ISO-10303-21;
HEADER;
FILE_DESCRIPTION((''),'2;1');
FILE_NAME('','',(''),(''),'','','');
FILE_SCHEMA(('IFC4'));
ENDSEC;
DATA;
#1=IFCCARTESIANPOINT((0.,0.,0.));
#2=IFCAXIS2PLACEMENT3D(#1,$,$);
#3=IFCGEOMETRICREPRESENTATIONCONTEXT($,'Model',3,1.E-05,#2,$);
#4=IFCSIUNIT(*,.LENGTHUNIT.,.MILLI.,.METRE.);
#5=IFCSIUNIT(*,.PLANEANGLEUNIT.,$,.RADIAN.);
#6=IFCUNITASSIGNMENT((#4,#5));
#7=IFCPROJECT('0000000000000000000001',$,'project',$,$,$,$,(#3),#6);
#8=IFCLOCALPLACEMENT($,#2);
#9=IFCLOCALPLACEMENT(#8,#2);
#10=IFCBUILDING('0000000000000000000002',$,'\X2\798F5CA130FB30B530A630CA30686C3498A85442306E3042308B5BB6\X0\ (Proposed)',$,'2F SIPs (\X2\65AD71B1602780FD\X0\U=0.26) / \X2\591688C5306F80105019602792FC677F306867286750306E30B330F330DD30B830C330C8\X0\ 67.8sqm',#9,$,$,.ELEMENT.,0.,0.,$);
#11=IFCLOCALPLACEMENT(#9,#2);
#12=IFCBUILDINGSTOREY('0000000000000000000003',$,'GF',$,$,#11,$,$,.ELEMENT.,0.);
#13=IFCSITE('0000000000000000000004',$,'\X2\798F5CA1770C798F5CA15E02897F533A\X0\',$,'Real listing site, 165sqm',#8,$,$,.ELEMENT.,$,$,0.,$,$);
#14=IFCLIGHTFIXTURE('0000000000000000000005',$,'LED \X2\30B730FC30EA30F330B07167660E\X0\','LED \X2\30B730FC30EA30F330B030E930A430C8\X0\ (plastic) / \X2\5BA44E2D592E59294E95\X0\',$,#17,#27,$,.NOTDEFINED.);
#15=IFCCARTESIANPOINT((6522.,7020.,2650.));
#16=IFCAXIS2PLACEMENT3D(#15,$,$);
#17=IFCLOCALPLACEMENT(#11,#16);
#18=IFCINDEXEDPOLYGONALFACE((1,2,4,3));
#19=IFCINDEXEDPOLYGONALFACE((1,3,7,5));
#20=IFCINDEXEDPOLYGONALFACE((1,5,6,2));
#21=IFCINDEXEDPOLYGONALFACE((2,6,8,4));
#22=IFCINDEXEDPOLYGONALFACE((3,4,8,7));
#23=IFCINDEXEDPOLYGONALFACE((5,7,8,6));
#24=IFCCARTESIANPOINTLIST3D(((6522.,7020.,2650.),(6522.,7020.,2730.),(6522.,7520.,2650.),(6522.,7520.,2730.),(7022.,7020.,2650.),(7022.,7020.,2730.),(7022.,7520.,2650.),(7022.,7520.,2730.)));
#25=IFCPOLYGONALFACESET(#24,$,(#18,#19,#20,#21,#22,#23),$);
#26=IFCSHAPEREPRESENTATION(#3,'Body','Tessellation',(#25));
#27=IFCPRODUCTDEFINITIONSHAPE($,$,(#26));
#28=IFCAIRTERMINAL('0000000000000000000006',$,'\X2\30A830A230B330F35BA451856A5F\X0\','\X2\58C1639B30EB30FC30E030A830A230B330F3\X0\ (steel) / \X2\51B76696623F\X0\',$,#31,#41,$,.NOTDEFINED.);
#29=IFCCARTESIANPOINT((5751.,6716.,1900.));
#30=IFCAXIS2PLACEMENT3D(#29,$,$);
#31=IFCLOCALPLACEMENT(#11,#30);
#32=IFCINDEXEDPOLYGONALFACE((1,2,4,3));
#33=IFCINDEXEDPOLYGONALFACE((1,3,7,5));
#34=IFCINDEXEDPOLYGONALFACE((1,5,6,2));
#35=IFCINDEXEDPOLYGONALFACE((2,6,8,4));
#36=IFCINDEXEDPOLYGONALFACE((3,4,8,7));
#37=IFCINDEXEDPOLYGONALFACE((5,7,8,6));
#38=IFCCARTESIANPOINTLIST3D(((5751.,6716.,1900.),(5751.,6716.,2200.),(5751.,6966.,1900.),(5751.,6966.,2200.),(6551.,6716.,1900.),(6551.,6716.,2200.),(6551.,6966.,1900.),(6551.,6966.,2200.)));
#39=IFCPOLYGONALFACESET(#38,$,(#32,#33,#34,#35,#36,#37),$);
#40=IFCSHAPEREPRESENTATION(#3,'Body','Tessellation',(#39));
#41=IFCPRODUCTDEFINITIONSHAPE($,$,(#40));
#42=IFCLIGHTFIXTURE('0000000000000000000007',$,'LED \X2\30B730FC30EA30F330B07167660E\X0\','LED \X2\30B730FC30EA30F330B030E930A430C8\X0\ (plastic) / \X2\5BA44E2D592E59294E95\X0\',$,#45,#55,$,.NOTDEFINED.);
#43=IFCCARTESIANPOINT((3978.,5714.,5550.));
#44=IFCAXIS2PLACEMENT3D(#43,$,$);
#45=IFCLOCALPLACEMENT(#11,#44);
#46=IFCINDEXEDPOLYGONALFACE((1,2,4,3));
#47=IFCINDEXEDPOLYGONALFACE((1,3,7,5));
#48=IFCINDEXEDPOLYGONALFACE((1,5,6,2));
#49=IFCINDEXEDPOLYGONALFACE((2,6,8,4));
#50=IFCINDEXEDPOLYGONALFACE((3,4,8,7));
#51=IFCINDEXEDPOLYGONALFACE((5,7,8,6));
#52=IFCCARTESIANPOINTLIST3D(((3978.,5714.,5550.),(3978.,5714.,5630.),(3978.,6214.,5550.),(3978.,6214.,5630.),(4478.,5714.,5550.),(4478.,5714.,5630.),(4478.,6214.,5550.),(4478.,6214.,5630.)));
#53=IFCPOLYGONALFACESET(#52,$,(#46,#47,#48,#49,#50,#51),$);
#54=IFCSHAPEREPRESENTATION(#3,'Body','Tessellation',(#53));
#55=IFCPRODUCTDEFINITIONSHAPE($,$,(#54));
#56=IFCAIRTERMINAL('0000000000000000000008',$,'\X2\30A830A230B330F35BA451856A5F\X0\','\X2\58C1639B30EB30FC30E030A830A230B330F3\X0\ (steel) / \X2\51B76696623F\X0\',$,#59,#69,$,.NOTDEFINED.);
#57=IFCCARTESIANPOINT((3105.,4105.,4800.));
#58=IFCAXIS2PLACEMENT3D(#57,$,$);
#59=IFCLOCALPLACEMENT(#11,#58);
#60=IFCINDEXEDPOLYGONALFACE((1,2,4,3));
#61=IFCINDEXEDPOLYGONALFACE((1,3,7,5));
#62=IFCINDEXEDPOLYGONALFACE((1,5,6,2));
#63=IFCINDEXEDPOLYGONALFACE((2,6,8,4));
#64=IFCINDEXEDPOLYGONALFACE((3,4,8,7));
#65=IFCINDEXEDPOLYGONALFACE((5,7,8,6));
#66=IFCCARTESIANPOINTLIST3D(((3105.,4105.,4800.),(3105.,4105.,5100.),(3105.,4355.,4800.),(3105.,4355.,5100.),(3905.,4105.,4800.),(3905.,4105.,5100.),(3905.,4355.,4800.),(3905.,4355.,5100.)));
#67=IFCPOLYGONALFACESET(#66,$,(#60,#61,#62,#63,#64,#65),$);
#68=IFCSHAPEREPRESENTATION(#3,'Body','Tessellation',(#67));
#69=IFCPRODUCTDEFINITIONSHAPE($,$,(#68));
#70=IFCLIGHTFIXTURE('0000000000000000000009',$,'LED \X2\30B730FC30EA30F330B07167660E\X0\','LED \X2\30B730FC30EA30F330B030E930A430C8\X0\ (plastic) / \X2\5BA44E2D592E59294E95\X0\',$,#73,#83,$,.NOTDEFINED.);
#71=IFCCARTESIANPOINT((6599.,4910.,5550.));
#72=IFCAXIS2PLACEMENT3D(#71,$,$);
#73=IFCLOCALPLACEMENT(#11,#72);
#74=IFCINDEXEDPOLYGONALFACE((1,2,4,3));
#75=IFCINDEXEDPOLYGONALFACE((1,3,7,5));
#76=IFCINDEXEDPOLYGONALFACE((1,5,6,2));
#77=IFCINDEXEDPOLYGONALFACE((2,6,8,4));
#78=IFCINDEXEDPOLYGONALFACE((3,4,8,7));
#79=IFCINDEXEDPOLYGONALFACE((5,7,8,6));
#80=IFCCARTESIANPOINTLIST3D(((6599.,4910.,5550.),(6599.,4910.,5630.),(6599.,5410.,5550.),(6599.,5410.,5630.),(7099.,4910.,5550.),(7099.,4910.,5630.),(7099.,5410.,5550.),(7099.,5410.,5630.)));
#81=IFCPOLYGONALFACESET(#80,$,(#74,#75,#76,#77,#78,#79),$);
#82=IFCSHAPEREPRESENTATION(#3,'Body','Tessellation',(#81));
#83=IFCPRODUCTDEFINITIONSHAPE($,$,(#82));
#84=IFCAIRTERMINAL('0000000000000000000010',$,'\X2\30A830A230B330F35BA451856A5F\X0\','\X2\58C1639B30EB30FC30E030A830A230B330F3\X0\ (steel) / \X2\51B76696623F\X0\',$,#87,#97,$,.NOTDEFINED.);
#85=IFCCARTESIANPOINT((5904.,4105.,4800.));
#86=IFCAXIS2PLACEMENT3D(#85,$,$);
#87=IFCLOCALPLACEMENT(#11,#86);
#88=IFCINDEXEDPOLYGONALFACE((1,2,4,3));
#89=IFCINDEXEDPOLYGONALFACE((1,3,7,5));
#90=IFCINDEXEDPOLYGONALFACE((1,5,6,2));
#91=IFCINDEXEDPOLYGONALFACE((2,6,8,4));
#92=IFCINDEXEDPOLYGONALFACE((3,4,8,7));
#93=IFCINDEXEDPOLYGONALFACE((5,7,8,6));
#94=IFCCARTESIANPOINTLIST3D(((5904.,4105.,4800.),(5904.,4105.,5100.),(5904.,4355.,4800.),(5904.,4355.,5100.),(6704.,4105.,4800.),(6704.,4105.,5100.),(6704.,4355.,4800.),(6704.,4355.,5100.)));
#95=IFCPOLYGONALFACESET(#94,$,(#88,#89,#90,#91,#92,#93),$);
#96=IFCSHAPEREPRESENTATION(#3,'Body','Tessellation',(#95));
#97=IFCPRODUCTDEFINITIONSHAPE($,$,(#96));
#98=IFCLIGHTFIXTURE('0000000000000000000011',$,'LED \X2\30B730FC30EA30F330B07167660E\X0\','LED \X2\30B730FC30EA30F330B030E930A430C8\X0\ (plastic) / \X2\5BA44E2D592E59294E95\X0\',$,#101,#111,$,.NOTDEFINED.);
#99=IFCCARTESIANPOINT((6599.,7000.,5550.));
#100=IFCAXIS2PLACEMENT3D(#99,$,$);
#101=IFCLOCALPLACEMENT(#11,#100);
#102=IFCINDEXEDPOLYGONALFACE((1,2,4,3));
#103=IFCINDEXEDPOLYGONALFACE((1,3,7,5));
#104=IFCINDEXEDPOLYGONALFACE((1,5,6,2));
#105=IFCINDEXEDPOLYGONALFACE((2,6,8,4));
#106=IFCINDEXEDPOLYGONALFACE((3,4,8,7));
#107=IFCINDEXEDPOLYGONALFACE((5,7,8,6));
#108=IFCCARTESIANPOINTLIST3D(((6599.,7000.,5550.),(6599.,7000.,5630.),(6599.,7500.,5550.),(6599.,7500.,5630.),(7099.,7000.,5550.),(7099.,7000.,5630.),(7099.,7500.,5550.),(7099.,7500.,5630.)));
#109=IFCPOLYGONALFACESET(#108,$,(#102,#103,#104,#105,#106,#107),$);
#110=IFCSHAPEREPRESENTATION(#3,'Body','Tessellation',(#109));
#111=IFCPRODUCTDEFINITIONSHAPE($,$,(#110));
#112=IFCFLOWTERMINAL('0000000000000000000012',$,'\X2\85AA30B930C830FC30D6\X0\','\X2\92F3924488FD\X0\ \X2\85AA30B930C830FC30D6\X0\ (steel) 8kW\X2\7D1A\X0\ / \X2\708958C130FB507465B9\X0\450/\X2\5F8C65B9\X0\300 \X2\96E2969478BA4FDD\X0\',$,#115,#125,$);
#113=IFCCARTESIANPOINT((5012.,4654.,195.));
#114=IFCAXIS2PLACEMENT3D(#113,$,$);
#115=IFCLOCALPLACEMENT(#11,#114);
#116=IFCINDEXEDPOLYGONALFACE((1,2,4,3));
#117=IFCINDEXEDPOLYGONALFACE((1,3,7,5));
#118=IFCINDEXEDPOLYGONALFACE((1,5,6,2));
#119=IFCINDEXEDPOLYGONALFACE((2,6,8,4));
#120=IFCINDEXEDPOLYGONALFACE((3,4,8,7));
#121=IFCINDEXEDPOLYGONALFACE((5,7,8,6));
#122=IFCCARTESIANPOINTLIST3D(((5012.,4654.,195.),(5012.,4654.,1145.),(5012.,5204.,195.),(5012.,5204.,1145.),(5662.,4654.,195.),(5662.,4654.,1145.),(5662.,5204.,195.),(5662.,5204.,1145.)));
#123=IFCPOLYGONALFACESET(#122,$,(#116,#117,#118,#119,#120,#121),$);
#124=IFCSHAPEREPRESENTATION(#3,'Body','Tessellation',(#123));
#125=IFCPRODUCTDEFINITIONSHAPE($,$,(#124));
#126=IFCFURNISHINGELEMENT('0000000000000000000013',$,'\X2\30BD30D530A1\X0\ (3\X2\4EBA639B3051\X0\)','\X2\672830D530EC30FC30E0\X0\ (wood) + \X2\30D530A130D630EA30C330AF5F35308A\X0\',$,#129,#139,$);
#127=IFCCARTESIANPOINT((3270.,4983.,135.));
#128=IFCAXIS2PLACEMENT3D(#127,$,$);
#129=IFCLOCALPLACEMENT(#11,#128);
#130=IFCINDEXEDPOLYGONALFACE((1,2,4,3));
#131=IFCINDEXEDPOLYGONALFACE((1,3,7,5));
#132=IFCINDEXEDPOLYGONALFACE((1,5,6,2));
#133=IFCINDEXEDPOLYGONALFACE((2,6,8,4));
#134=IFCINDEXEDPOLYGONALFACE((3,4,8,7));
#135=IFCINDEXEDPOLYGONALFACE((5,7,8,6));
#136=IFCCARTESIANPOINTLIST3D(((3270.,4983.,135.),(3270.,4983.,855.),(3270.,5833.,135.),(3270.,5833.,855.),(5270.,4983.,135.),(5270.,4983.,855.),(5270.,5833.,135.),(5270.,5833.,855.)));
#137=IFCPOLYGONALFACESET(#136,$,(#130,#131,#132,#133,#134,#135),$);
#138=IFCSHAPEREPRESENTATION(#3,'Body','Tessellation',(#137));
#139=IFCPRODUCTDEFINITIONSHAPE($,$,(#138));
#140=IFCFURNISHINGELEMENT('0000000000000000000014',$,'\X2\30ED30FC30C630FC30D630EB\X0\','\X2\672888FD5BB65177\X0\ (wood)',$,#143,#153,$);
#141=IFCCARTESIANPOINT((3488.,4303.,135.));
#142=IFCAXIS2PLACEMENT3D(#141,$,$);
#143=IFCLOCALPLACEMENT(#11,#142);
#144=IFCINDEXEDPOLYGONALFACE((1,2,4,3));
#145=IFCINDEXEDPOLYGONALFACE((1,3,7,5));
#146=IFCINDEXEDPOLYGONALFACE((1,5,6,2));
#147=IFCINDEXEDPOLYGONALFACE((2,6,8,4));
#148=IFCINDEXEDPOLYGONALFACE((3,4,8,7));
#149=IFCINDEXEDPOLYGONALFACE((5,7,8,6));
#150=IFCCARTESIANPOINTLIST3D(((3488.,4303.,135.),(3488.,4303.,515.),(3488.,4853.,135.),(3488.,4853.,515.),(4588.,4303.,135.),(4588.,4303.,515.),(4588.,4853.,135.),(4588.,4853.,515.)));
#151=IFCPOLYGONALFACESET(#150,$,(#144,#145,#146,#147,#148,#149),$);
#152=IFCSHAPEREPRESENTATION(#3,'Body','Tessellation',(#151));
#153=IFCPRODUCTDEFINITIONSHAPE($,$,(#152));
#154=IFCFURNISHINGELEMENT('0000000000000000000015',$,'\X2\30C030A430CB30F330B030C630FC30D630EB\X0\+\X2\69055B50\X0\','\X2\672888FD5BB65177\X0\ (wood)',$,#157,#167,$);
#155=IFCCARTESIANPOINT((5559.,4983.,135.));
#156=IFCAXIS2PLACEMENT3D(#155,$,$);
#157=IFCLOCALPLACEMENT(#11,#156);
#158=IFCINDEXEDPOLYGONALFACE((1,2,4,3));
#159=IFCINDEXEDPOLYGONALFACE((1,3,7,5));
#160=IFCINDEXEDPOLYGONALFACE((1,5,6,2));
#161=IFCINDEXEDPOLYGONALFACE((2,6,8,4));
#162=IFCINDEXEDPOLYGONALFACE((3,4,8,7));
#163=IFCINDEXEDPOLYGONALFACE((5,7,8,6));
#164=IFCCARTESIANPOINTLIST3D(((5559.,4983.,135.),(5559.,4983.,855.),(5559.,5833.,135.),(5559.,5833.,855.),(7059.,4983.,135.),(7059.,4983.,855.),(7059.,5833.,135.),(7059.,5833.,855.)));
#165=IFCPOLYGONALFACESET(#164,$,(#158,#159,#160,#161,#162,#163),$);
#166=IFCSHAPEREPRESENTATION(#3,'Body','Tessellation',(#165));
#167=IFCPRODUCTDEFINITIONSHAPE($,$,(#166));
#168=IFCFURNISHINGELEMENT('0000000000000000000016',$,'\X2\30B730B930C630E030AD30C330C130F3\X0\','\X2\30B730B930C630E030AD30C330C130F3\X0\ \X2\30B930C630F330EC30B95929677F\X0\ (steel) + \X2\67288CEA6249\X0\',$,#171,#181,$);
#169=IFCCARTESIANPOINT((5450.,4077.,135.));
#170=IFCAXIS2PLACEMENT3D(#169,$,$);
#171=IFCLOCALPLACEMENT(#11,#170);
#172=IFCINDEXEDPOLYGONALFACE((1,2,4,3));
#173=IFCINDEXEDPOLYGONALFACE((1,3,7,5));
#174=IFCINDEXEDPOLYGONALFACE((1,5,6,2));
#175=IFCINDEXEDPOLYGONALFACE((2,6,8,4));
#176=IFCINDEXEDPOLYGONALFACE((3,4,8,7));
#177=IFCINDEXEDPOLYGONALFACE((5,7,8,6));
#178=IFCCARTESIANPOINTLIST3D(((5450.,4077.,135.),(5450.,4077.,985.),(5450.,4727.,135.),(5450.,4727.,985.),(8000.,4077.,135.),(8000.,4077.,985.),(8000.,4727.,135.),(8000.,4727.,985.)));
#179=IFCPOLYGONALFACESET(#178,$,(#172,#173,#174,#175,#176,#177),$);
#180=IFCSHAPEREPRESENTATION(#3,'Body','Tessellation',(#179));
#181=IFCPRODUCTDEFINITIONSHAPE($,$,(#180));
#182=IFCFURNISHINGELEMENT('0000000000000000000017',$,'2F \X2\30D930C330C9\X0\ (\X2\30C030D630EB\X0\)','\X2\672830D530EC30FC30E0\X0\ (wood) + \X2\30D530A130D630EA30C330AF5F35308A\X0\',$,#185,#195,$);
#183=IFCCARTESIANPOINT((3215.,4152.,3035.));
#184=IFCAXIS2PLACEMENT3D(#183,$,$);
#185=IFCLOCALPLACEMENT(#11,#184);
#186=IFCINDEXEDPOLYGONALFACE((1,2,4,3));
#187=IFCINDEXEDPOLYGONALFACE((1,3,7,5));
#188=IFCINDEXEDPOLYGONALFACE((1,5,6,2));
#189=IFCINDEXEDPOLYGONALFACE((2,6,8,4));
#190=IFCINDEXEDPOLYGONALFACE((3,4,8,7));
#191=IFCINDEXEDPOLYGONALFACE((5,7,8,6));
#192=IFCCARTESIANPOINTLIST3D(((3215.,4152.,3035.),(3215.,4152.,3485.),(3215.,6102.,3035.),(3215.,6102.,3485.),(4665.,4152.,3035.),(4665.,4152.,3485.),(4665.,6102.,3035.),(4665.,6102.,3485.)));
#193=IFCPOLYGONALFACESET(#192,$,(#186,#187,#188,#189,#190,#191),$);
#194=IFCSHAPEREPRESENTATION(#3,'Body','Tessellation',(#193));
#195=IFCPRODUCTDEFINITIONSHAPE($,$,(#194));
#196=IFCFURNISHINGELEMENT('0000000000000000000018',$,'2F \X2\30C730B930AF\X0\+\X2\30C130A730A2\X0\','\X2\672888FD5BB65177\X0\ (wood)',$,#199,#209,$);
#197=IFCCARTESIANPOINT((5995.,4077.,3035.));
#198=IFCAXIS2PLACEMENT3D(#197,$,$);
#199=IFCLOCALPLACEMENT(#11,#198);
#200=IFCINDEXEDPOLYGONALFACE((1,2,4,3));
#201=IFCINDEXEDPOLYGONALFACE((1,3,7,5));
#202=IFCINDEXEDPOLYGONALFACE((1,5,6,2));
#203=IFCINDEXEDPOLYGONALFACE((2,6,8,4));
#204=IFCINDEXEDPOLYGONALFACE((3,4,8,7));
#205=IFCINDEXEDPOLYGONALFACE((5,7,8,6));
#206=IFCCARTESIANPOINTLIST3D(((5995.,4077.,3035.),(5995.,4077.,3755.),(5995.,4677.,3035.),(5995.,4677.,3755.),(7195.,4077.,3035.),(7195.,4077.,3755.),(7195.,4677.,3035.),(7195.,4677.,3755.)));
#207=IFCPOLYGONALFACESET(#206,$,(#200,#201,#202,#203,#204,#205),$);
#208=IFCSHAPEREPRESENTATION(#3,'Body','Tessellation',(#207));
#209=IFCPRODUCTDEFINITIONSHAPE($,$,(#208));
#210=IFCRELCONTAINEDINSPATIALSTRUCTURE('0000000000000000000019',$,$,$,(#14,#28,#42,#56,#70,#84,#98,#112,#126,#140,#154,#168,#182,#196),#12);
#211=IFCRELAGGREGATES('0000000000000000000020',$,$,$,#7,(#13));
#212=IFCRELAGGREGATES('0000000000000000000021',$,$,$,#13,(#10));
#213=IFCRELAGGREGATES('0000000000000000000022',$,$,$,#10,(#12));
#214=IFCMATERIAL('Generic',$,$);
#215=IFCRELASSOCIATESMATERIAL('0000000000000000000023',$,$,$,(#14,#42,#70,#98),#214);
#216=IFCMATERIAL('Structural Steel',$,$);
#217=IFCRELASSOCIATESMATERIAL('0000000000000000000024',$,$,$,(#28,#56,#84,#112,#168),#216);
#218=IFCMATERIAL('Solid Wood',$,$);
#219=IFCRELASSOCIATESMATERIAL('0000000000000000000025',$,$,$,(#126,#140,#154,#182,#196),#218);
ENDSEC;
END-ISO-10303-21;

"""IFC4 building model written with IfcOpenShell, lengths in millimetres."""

from ifc_helpers import new_model, si_unit, frame, frame_2d, origin, place, context, project, spatial, rectangle, extrude, material, element, save


model = new_model("IFC4")

# Units and contexts
model_context = context("Model", 3, precision=1e-05, world=origin())
ifc_project = project(units=[si_unit("LENGTHUNIT", "METRE", prefix="MILLI"), si_unit("PLANEANGLEUNIT", "RADIAN")], contexts=[model_context])

# Site, building, storey
site_placement = place(None, origin())
site = spatial("IfcSite", under=ifc_project, at=site_placement, Name="福岡県福岡市西区", ObjectType="Real listing site, 165sqm", CompositionType="ELEMENT", RefElevation=0.0)
building_placement = place(site_placement, origin())
building = spatial("IfcBuilding", under=site, at=building_placement, Name="福岡・サウナと水風呂のある家 (Proposed)", ObjectType="2F SIPs (断熱性能U=0.26) / 外装は耐候性鋼板と木材のコンポジット 67.8sqm", CompositionType="ELEMENT", ElevationOfRefHeight=0.0, ElevationOfTerrain=0.0)
storey_placement = place(building_placement, origin())
storey = spatial("IfcBuildingStorey", under=building, at=storey_placement, Name="GF", CompositionType="ELEMENT", Elevation=0.0)

# Shared definitions
ifc_material_1 = material(Name="Solid Wood")

# Shared definitions
ifc_material_2 = material(Name="Structural Steel")

# Shared definitions
ifc_material_3 = material(Name="Generic")

# Light fixture
light_fixture_1_placement = place(storey_placement, frame((6522.0, 7020.0, 2650.0)))
element("IfcLightFixture", 1, at=light_fixture_1_placement, inside=storey, material=ifc_material_3, Name="LED シーリング照明", Description="LED シーリングライト (plastic) / 室中央天井", PredefinedType="NOTDEFINED", context=model_context, shape_type="SweptSolid", body=[
    extrude(rectangle(XDim=500.0, YDim=500.0, at=frame_2d((250.0, 250.0))), frame((6522.0, 7020.0, 2650.0)), (0.0, 0.0, 1.0), 80.0),
])

# Air terminal
air_terminal_1_placement = place(storey_placement, frame((5751.0, 6716.0, 1900.0)))
element("IfcAirTerminal", 2, at=air_terminal_1_placement, inside=storey, material=ifc_material_2, Name="エアコン室内機", Description="壁掛ルームエアコン (steel) / 冷暖房", PredefinedType="NOTDEFINED", context=model_context, shape_type="SweptSolid", body=[
    extrude(rectangle(XDim=800.0, YDim=250.0, at=frame_2d((400.0, 125.0))), frame((5751.0, 6716.0, 1900.0)), (0.0, 0.0, 1.0), 300.0),
])

# Light fixture
light_fixture_2_placement = place(storey_placement, frame((3978.0, 5714.0, 5550.0)))
element("IfcLightFixture", 3, at=light_fixture_2_placement, inside=storey, material=ifc_material_3, Name="LED シーリング照明", Description="LED シーリングライト (plastic) / 室中央天井", PredefinedType="NOTDEFINED", context=model_context, shape_type="SweptSolid", body=[
    extrude(rectangle(XDim=500.0, YDim=500.0, at=frame_2d((250.0, 250.0))), frame((3978.0, 5714.0, 5550.0)), (0.0, 0.0, 1.0), 80.0),
])

# Air terminal
air_terminal_2_placement = place(storey_placement, frame((3105.0, 4105.0, 4800.0)))
element("IfcAirTerminal", 4, at=air_terminal_2_placement, inside=storey, material=ifc_material_2, Name="エアコン室内機", Description="壁掛ルームエアコン (steel) / 冷暖房", PredefinedType="NOTDEFINED", context=model_context, shape_type="SweptSolid", body=[
    extrude(rectangle(XDim=800.0, YDim=250.0, at=frame_2d((400.0, 125.0))), frame((3105.0, 4105.0, 4800.0)), (0.0, 0.0, 1.0), 300.0),
])

# Light fixture
light_fixture_3_placement = place(storey_placement, frame((6599.0, 4910.0, 5550.0)))
element("IfcLightFixture", 5, at=light_fixture_3_placement, inside=storey, material=ifc_material_3, Name="LED シーリング照明", Description="LED シーリングライト (plastic) / 室中央天井", PredefinedType="NOTDEFINED", context=model_context, shape_type="SweptSolid", body=[
    extrude(rectangle(XDim=500.0, YDim=500.0, at=frame_2d((250.0, 250.0))), frame((6599.0, 4910.0, 5550.0)), (0.0, 0.0, 1.0), 80.0),
])

# Air terminal
air_terminal_3_placement = place(storey_placement, frame((5904.0, 4105.0, 4800.0)))
element("IfcAirTerminal", 6, at=air_terminal_3_placement, inside=storey, material=ifc_material_2, Name="エアコン室内機", Description="壁掛ルームエアコン (steel) / 冷暖房", PredefinedType="NOTDEFINED", context=model_context, shape_type="SweptSolid", body=[
    extrude(rectangle(XDim=800.0, YDim=250.0, at=frame_2d((400.0, 125.0))), frame((5904.0, 4105.0, 4800.0)), (0.0, 0.0, 1.0), 300.0),
])

# Light fixture
light_fixture_4_placement = place(storey_placement, frame((6599.0, 7000.0, 5550.0)))
element("IfcLightFixture", 7, at=light_fixture_4_placement, inside=storey, material=ifc_material_3, Name="LED シーリング照明", Description="LED シーリングライト (plastic) / 室中央天井", PredefinedType="NOTDEFINED", context=model_context, shape_type="SweptSolid", body=[
    extrude(rectangle(XDim=500.0, YDim=500.0, at=frame_2d((250.0, 250.0))), frame((6599.0, 7000.0, 5550.0)), (0.0, 0.0, 1.0), 80.0),
])

# Flow terminal
flow_terminal_1_placement = place(storey_placement, frame((5012.0, 4654.0, 195.0)))
element("IfcFlowTerminal", 8, at=flow_terminal_1_placement, inside=storey, material=ifc_material_2, Name="薪ストーブ", Description="鋳鉄製 薪ストーブ (steel) 8kW級 / 炉壁・側方450/後方300 離隔確保", context=model_context, shape_type="SweptSolid", body=[
    extrude(rectangle(XDim=650.0, YDim=550.0, at=frame_2d((325.0, 275.0))), frame((5012.0, 4654.0, 195.0)), (0.0, 0.0, 1.0), 950.0),
])

# Furnishing elements
furnishing_1_placement = place(storey_placement, frame((3270.0, 4983.0, 135.0)))
element("IfcFurnishingElement", 9, at=furnishing_1_placement, inside=storey, material=ifc_material_1, Name="ソファ (3人掛け)", Description="木フレーム (wood) + ファブリック張り", context=model_context, shape_type="SweptSolid", body=[
    extrude(rectangle(XDim=2000.0, YDim=850.0, at=frame_2d((1000.0, 425.0))), frame((3270.0, 4983.0, 135.0)), (0.0, 0.0, 1.0), 720.0),
])
furnishing_2_placement = place(storey_placement, frame((3488.0, 4303.0, 135.0)))
element("IfcFurnishingElement", 10, at=furnishing_2_placement, inside=storey, material=ifc_material_1, Name="ローテーブル", Description="木製家具 (wood)", context=model_context, shape_type="SweptSolid", body=[
    extrude(rectangle(XDim=1100.0, YDim=550.0, at=frame_2d((550.0, 275.0))), frame((3488.0, 4303.0, 135.0)), (0.0, 0.0, 1.0), 380.0),
])
furnishing_3_placement = place(storey_placement, frame((5559.0, 4983.0, 135.0)))
element("IfcFurnishingElement", 11, at=furnishing_3_placement, inside=storey, material=ifc_material_1, Name="ダイニングテーブル+椅子", Description="木製家具 (wood)", context=model_context, shape_type="SweptSolid", body=[
    extrude(rectangle(XDim=1500.0, YDim=850.0, at=frame_2d((750.0, 425.0))), frame((5559.0, 4983.0, 135.0)), (0.0, 0.0, 1.0), 720.0),
])
furnishing_4_placement = place(storey_placement, frame((5450.0, 4077.0, 135.0)))
element("IfcFurnishingElement", 12, at=furnishing_4_placement, inside=storey, material=ifc_material_2, Name="システムキッチン", Description="システムキッチン ステンレス天板 (steel) + 木質扉", context=model_context, shape_type="SweptSolid", body=[
    extrude(rectangle(XDim=2550.0, YDim=650.0, at=frame_2d((1275.0, 325.0))), frame((5450.0, 4077.0, 135.0)), (0.0, 0.0, 1.0), 850.0),
])
furnishing_5_placement = place(storey_placement, frame((3215.0, 4152.0, 3035.0)))
element("IfcFurnishingElement", 13, at=furnishing_5_placement, inside=storey, material=ifc_material_1, Name="2F ベッド (ダブル)", Description="木フレーム (wood) + ファブリック張り", context=model_context, shape_type="SweptSolid", body=[
    extrude(rectangle(XDim=1450.0, YDim=1950.0, at=frame_2d((725.0, 975.0))), frame((3215.0, 4152.0, 3035.0)), (0.0, 0.0, 1.0), 450.0),
])
furnishing_6_placement = place(storey_placement, frame((5995.0, 4077.0, 3035.0)))
element("IfcFurnishingElement", 14, at=furnishing_6_placement, inside=storey, material=ifc_material_1, Name="2F デスク+チェア", Description="木製家具 (wood)", context=model_context, shape_type="SweptSolid", body=[
    extrude(rectangle(XDim=1200.0, YDim=600.0, at=frame_2d((600.0, 300.0))), frame((5995.0, 4077.0, 3035.0)), (0.0, 0.0, 1.0), 720.0),
])

save(model, "model.ifc")
